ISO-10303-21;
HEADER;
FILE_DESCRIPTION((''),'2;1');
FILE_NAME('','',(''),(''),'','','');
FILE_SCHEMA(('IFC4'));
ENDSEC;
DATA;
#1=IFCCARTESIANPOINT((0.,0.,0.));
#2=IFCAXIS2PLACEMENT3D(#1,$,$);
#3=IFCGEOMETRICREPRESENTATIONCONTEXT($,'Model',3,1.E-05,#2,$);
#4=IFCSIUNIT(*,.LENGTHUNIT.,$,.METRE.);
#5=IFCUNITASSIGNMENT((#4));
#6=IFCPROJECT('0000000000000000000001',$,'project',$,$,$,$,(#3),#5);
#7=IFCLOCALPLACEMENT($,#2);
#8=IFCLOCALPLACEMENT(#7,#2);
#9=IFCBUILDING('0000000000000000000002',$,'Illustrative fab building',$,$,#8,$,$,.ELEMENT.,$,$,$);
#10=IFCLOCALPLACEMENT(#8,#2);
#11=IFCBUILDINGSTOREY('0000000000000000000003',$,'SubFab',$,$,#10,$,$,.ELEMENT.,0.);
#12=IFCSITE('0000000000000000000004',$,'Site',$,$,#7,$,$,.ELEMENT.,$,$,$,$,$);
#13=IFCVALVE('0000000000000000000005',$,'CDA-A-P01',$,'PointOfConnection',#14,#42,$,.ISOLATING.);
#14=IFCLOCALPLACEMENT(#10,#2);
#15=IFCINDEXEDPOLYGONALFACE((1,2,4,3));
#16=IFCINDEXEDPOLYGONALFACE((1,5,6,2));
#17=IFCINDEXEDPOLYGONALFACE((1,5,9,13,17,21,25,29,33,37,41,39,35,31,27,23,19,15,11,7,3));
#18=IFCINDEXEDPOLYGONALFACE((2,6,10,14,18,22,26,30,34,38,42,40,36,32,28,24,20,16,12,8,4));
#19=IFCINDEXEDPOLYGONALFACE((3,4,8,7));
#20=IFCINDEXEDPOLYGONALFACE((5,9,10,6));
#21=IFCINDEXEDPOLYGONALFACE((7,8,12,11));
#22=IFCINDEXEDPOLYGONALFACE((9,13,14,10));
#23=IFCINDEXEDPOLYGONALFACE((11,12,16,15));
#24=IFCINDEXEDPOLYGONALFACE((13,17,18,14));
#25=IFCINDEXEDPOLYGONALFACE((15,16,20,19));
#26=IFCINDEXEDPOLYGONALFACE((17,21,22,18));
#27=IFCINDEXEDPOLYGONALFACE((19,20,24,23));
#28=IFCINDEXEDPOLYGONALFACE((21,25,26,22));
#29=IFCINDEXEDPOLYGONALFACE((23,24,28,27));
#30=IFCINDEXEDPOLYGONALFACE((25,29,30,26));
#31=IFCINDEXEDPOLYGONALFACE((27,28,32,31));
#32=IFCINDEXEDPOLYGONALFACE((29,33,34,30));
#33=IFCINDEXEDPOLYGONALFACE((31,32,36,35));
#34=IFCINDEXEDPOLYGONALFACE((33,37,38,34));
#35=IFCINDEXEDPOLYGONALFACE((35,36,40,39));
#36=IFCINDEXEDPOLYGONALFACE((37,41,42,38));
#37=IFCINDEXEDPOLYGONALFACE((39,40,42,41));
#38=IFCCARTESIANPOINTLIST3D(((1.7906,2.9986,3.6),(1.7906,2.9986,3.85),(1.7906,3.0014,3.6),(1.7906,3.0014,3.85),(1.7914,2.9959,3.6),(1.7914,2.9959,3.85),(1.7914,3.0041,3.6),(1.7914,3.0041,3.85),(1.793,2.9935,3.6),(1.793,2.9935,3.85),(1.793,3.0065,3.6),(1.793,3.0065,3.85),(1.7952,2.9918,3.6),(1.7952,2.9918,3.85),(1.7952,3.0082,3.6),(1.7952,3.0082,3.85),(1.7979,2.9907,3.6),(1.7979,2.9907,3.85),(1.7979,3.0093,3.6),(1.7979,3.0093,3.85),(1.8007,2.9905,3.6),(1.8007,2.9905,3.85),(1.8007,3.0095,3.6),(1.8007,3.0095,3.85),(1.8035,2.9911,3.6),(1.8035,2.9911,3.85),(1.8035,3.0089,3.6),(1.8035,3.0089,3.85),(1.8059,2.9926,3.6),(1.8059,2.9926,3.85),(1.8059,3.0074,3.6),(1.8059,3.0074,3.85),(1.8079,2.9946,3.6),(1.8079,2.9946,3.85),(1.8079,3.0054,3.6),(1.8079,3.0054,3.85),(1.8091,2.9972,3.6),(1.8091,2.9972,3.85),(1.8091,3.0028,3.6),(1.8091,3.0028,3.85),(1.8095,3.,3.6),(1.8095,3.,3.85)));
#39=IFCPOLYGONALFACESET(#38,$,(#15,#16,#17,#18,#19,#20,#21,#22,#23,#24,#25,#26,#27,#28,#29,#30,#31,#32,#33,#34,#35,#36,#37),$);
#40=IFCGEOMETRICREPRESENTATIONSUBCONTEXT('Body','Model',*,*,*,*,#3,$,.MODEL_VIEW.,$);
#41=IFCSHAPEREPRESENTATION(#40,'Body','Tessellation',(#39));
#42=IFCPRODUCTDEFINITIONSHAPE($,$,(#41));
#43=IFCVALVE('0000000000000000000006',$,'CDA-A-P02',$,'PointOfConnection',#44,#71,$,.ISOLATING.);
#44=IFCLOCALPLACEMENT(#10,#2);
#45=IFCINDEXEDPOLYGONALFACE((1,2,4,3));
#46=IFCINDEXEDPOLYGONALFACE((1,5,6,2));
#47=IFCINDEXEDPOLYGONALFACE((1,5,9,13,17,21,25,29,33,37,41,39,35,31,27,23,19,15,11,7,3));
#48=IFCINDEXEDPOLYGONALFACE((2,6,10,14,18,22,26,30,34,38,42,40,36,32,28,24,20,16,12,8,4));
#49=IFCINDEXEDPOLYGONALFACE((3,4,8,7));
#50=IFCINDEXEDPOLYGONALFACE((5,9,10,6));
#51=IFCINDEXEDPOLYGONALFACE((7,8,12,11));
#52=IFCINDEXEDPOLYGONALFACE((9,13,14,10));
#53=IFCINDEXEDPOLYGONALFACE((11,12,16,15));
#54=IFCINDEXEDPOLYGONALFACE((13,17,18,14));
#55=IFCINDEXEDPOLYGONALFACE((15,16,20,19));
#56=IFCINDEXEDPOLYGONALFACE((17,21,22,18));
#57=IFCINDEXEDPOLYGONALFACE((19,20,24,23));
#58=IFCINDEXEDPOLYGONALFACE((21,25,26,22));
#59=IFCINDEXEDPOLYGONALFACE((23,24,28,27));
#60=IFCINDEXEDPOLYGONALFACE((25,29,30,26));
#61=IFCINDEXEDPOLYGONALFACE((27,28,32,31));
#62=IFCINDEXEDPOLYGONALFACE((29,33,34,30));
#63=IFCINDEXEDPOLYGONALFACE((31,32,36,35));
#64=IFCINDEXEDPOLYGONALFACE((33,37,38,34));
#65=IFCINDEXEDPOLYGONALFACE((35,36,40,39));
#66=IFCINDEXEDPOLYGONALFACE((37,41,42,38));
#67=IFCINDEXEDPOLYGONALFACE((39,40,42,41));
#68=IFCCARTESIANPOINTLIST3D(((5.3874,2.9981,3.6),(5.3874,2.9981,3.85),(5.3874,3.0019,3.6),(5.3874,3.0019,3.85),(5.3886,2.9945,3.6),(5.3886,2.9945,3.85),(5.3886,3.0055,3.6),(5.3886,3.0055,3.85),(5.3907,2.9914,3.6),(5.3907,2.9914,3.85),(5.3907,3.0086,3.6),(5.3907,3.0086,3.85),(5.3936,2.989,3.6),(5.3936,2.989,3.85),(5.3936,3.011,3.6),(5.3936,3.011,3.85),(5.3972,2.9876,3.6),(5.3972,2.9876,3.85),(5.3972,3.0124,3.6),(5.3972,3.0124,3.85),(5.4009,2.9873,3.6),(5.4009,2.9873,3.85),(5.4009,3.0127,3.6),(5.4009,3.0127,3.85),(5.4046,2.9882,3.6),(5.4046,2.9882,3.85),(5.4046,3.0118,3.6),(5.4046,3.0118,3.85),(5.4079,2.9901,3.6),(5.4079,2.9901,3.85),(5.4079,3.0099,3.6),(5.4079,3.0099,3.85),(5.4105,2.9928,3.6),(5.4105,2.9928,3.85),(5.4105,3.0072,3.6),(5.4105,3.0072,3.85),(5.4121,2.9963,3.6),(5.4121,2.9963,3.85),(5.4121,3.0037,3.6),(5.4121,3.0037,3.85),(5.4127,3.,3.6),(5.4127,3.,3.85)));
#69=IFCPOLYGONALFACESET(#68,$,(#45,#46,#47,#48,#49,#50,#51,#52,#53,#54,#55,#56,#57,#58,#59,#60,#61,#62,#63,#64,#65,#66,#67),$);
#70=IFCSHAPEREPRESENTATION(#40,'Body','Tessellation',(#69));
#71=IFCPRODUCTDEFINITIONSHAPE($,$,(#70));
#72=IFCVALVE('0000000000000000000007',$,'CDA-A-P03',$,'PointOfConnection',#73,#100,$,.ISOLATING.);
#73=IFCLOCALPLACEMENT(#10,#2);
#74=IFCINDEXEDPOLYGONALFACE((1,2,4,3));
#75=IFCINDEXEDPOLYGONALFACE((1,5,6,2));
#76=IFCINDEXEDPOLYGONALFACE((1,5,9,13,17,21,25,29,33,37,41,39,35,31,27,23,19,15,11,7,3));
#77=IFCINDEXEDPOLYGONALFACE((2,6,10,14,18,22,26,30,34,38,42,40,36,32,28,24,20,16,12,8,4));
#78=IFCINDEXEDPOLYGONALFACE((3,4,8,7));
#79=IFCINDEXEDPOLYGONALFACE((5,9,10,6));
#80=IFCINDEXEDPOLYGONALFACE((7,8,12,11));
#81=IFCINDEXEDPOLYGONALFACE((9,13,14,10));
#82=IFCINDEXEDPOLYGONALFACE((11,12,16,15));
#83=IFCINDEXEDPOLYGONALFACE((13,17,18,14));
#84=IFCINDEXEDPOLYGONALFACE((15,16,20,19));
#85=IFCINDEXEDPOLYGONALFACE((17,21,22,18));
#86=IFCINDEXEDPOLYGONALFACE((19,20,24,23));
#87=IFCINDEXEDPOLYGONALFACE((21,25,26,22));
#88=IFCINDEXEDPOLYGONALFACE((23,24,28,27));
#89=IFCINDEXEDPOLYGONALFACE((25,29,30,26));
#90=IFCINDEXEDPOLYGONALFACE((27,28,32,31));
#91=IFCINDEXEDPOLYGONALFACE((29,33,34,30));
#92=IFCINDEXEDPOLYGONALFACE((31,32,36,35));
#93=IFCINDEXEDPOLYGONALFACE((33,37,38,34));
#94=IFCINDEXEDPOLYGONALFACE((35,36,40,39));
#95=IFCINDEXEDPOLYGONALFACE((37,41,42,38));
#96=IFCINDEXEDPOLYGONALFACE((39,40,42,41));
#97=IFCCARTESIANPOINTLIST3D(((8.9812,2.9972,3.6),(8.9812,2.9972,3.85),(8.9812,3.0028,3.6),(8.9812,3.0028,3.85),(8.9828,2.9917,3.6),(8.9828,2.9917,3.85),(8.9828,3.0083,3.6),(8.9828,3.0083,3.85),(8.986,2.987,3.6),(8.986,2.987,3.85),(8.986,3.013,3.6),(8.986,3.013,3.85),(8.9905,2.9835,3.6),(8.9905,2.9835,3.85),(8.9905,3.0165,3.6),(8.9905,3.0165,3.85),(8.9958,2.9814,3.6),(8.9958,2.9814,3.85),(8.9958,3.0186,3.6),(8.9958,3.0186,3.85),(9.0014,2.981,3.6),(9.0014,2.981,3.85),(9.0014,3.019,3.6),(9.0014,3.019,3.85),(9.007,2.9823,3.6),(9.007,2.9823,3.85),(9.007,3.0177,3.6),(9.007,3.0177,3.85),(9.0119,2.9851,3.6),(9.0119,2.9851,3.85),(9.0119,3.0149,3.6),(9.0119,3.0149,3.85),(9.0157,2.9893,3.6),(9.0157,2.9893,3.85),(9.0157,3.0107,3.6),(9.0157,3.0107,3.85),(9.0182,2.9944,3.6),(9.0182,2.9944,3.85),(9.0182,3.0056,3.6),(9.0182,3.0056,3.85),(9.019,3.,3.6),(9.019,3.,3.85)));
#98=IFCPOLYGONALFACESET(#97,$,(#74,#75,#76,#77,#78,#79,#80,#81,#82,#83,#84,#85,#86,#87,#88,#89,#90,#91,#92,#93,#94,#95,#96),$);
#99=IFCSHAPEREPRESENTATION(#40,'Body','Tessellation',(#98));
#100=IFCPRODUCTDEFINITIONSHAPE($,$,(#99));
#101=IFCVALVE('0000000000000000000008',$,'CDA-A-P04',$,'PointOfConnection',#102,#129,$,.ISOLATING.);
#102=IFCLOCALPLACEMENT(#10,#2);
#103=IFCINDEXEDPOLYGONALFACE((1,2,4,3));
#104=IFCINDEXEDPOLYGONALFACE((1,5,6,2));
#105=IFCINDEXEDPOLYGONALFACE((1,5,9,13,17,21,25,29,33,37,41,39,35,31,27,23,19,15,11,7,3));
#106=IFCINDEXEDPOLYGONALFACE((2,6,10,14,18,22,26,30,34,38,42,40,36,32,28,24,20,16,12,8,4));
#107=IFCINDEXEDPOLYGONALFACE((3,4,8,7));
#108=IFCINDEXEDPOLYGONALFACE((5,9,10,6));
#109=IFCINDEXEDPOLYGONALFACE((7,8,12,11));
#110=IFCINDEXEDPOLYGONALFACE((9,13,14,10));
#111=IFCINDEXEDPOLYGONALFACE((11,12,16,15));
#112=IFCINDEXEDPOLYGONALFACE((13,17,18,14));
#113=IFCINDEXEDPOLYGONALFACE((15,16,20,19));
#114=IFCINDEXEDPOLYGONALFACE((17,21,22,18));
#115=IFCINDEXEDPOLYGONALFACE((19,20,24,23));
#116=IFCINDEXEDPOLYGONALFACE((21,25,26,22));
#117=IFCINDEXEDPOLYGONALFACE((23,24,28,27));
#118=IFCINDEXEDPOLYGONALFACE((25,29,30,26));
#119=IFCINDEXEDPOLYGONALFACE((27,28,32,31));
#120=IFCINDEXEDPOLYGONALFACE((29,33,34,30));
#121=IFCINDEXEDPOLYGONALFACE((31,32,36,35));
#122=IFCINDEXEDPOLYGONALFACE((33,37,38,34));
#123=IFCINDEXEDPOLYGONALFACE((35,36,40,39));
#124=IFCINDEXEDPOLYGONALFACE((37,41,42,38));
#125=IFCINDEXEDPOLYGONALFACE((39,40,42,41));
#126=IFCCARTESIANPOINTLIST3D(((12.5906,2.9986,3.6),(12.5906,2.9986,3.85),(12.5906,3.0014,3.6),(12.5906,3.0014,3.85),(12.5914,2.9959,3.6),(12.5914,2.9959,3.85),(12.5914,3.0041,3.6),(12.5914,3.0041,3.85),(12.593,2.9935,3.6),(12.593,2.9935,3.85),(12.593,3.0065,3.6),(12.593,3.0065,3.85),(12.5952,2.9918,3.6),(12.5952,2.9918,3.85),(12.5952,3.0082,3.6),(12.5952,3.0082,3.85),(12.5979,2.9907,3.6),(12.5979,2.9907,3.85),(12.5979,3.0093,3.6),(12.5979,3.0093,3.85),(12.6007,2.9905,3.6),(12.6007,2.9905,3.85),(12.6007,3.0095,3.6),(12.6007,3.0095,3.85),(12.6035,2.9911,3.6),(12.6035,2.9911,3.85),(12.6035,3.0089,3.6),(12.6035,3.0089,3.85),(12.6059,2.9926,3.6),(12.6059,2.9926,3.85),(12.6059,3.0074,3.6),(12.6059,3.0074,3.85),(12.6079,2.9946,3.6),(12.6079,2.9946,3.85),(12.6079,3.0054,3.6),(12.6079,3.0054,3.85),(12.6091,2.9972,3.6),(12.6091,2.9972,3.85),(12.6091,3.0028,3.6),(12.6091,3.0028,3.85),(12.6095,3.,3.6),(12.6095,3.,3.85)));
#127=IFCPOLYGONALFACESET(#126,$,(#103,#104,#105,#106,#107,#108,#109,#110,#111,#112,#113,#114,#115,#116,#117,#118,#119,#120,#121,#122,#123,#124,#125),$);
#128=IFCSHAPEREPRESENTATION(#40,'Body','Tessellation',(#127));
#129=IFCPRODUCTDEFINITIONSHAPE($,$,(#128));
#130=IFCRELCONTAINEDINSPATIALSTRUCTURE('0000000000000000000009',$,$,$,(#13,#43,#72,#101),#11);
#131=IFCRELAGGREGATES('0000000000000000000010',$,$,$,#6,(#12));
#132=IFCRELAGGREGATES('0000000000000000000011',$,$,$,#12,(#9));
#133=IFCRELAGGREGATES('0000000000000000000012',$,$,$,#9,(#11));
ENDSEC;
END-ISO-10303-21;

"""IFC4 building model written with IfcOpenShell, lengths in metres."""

from ifc_helpers import new_model, entity, si_unit, frame, origin, place, context, subcontext, project, spatial, element, save


model = new_model("IFC4")

# Units and contexts
model_context = context("Model", 3, precision=1e-05, world=origin())
body_context = subcontext(model_context, "Body", "Model", "MODEL_VIEW")
ifc_project = project(units=[si_unit("LENGTHUNIT", "METRE")], contexts=[model_context])

# Site, building, storey
site_placement = place(None, origin())
site = spatial("IfcSite", under=ifc_project, at=site_placement, Name="Site", CompositionType="ELEMENT")
building_placement = place(site_placement, origin())
building = spatial("IfcBuilding", under=site, at=building_placement, Name="Illustrative fab building", CompositionType="ELEMENT")
storey_placement = place(building_placement, origin())
storey = spatial("IfcBuildingStorey", under=building, at=storey_placement, Name="SubFab", CompositionType="ELEMENT", Elevation=0.0)

# Valves
valve_1_placement = place(storey_placement, frame((1.8, 3.0, 3.6)))
element("IfcValve", 1, at=valve_1_placement, inside=storey, Name="CDA-A-P01", ObjectType="PointOfConnection", PredefinedType="ISOLATING", context=body_context, shape_type="AdvancedSweptSolid", body=[
    entity("IfcSweptDiskSolid", entity("IfcPolyline", [entity("IfcCartesianPoint", [0.0, 0.0, 0.0]), entity("IfcCartesianPoint", [0.0, 0.0, 0.25])]), 0.0095),
])
valve_2_placement = place(storey_placement, frame((5.4, 3.0, 3.6)))
element("IfcValve", 2, at=valve_2_placement, inside=storey, Name="CDA-A-P02", ObjectType="PointOfConnection", PredefinedType="ISOLATING", context=body_context, shape_type="AdvancedSweptSolid", body=[
    entity("IfcSweptDiskSolid", entity("IfcPolyline", [entity("IfcCartesianPoint", [0.0, 0.0, 0.0]), entity("IfcCartesianPoint", [0.0, 0.0, 0.25])]), 0.0127),
])
valve_3_placement = place(storey_placement, frame((9.0, 3.0, 3.6)))
element("IfcValve", 3, at=valve_3_placement, inside=storey, Name="CDA-A-P03", ObjectType="PointOfConnection", PredefinedType="ISOLATING", context=body_context, shape_type="AdvancedSweptSolid", body=[
    entity("IfcSweptDiskSolid", entity("IfcPolyline", [entity("IfcCartesianPoint", [0.0, 0.0, 0.0]), entity("IfcCartesianPoint", [0.0, 0.0, 0.25])]), 0.019),
])
valve_4_placement = place(storey_placement, frame((12.6, 3.0, 3.6)))
element("IfcValve", 4, at=valve_4_placement, inside=storey, Name="CDA-A-P04", ObjectType="PointOfConnection", PredefinedType="ISOLATING", context=body_context, shape_type="AdvancedSweptSolid", body=[
    entity("IfcSweptDiskSolid", entity("IfcPolyline", [entity("IfcCartesianPoint", [0.0, 0.0, 0.0]), entity("IfcCartesianPoint", [0.0, 0.0, 0.25])]), 0.0095),
])

save(model, "model.ifc")
